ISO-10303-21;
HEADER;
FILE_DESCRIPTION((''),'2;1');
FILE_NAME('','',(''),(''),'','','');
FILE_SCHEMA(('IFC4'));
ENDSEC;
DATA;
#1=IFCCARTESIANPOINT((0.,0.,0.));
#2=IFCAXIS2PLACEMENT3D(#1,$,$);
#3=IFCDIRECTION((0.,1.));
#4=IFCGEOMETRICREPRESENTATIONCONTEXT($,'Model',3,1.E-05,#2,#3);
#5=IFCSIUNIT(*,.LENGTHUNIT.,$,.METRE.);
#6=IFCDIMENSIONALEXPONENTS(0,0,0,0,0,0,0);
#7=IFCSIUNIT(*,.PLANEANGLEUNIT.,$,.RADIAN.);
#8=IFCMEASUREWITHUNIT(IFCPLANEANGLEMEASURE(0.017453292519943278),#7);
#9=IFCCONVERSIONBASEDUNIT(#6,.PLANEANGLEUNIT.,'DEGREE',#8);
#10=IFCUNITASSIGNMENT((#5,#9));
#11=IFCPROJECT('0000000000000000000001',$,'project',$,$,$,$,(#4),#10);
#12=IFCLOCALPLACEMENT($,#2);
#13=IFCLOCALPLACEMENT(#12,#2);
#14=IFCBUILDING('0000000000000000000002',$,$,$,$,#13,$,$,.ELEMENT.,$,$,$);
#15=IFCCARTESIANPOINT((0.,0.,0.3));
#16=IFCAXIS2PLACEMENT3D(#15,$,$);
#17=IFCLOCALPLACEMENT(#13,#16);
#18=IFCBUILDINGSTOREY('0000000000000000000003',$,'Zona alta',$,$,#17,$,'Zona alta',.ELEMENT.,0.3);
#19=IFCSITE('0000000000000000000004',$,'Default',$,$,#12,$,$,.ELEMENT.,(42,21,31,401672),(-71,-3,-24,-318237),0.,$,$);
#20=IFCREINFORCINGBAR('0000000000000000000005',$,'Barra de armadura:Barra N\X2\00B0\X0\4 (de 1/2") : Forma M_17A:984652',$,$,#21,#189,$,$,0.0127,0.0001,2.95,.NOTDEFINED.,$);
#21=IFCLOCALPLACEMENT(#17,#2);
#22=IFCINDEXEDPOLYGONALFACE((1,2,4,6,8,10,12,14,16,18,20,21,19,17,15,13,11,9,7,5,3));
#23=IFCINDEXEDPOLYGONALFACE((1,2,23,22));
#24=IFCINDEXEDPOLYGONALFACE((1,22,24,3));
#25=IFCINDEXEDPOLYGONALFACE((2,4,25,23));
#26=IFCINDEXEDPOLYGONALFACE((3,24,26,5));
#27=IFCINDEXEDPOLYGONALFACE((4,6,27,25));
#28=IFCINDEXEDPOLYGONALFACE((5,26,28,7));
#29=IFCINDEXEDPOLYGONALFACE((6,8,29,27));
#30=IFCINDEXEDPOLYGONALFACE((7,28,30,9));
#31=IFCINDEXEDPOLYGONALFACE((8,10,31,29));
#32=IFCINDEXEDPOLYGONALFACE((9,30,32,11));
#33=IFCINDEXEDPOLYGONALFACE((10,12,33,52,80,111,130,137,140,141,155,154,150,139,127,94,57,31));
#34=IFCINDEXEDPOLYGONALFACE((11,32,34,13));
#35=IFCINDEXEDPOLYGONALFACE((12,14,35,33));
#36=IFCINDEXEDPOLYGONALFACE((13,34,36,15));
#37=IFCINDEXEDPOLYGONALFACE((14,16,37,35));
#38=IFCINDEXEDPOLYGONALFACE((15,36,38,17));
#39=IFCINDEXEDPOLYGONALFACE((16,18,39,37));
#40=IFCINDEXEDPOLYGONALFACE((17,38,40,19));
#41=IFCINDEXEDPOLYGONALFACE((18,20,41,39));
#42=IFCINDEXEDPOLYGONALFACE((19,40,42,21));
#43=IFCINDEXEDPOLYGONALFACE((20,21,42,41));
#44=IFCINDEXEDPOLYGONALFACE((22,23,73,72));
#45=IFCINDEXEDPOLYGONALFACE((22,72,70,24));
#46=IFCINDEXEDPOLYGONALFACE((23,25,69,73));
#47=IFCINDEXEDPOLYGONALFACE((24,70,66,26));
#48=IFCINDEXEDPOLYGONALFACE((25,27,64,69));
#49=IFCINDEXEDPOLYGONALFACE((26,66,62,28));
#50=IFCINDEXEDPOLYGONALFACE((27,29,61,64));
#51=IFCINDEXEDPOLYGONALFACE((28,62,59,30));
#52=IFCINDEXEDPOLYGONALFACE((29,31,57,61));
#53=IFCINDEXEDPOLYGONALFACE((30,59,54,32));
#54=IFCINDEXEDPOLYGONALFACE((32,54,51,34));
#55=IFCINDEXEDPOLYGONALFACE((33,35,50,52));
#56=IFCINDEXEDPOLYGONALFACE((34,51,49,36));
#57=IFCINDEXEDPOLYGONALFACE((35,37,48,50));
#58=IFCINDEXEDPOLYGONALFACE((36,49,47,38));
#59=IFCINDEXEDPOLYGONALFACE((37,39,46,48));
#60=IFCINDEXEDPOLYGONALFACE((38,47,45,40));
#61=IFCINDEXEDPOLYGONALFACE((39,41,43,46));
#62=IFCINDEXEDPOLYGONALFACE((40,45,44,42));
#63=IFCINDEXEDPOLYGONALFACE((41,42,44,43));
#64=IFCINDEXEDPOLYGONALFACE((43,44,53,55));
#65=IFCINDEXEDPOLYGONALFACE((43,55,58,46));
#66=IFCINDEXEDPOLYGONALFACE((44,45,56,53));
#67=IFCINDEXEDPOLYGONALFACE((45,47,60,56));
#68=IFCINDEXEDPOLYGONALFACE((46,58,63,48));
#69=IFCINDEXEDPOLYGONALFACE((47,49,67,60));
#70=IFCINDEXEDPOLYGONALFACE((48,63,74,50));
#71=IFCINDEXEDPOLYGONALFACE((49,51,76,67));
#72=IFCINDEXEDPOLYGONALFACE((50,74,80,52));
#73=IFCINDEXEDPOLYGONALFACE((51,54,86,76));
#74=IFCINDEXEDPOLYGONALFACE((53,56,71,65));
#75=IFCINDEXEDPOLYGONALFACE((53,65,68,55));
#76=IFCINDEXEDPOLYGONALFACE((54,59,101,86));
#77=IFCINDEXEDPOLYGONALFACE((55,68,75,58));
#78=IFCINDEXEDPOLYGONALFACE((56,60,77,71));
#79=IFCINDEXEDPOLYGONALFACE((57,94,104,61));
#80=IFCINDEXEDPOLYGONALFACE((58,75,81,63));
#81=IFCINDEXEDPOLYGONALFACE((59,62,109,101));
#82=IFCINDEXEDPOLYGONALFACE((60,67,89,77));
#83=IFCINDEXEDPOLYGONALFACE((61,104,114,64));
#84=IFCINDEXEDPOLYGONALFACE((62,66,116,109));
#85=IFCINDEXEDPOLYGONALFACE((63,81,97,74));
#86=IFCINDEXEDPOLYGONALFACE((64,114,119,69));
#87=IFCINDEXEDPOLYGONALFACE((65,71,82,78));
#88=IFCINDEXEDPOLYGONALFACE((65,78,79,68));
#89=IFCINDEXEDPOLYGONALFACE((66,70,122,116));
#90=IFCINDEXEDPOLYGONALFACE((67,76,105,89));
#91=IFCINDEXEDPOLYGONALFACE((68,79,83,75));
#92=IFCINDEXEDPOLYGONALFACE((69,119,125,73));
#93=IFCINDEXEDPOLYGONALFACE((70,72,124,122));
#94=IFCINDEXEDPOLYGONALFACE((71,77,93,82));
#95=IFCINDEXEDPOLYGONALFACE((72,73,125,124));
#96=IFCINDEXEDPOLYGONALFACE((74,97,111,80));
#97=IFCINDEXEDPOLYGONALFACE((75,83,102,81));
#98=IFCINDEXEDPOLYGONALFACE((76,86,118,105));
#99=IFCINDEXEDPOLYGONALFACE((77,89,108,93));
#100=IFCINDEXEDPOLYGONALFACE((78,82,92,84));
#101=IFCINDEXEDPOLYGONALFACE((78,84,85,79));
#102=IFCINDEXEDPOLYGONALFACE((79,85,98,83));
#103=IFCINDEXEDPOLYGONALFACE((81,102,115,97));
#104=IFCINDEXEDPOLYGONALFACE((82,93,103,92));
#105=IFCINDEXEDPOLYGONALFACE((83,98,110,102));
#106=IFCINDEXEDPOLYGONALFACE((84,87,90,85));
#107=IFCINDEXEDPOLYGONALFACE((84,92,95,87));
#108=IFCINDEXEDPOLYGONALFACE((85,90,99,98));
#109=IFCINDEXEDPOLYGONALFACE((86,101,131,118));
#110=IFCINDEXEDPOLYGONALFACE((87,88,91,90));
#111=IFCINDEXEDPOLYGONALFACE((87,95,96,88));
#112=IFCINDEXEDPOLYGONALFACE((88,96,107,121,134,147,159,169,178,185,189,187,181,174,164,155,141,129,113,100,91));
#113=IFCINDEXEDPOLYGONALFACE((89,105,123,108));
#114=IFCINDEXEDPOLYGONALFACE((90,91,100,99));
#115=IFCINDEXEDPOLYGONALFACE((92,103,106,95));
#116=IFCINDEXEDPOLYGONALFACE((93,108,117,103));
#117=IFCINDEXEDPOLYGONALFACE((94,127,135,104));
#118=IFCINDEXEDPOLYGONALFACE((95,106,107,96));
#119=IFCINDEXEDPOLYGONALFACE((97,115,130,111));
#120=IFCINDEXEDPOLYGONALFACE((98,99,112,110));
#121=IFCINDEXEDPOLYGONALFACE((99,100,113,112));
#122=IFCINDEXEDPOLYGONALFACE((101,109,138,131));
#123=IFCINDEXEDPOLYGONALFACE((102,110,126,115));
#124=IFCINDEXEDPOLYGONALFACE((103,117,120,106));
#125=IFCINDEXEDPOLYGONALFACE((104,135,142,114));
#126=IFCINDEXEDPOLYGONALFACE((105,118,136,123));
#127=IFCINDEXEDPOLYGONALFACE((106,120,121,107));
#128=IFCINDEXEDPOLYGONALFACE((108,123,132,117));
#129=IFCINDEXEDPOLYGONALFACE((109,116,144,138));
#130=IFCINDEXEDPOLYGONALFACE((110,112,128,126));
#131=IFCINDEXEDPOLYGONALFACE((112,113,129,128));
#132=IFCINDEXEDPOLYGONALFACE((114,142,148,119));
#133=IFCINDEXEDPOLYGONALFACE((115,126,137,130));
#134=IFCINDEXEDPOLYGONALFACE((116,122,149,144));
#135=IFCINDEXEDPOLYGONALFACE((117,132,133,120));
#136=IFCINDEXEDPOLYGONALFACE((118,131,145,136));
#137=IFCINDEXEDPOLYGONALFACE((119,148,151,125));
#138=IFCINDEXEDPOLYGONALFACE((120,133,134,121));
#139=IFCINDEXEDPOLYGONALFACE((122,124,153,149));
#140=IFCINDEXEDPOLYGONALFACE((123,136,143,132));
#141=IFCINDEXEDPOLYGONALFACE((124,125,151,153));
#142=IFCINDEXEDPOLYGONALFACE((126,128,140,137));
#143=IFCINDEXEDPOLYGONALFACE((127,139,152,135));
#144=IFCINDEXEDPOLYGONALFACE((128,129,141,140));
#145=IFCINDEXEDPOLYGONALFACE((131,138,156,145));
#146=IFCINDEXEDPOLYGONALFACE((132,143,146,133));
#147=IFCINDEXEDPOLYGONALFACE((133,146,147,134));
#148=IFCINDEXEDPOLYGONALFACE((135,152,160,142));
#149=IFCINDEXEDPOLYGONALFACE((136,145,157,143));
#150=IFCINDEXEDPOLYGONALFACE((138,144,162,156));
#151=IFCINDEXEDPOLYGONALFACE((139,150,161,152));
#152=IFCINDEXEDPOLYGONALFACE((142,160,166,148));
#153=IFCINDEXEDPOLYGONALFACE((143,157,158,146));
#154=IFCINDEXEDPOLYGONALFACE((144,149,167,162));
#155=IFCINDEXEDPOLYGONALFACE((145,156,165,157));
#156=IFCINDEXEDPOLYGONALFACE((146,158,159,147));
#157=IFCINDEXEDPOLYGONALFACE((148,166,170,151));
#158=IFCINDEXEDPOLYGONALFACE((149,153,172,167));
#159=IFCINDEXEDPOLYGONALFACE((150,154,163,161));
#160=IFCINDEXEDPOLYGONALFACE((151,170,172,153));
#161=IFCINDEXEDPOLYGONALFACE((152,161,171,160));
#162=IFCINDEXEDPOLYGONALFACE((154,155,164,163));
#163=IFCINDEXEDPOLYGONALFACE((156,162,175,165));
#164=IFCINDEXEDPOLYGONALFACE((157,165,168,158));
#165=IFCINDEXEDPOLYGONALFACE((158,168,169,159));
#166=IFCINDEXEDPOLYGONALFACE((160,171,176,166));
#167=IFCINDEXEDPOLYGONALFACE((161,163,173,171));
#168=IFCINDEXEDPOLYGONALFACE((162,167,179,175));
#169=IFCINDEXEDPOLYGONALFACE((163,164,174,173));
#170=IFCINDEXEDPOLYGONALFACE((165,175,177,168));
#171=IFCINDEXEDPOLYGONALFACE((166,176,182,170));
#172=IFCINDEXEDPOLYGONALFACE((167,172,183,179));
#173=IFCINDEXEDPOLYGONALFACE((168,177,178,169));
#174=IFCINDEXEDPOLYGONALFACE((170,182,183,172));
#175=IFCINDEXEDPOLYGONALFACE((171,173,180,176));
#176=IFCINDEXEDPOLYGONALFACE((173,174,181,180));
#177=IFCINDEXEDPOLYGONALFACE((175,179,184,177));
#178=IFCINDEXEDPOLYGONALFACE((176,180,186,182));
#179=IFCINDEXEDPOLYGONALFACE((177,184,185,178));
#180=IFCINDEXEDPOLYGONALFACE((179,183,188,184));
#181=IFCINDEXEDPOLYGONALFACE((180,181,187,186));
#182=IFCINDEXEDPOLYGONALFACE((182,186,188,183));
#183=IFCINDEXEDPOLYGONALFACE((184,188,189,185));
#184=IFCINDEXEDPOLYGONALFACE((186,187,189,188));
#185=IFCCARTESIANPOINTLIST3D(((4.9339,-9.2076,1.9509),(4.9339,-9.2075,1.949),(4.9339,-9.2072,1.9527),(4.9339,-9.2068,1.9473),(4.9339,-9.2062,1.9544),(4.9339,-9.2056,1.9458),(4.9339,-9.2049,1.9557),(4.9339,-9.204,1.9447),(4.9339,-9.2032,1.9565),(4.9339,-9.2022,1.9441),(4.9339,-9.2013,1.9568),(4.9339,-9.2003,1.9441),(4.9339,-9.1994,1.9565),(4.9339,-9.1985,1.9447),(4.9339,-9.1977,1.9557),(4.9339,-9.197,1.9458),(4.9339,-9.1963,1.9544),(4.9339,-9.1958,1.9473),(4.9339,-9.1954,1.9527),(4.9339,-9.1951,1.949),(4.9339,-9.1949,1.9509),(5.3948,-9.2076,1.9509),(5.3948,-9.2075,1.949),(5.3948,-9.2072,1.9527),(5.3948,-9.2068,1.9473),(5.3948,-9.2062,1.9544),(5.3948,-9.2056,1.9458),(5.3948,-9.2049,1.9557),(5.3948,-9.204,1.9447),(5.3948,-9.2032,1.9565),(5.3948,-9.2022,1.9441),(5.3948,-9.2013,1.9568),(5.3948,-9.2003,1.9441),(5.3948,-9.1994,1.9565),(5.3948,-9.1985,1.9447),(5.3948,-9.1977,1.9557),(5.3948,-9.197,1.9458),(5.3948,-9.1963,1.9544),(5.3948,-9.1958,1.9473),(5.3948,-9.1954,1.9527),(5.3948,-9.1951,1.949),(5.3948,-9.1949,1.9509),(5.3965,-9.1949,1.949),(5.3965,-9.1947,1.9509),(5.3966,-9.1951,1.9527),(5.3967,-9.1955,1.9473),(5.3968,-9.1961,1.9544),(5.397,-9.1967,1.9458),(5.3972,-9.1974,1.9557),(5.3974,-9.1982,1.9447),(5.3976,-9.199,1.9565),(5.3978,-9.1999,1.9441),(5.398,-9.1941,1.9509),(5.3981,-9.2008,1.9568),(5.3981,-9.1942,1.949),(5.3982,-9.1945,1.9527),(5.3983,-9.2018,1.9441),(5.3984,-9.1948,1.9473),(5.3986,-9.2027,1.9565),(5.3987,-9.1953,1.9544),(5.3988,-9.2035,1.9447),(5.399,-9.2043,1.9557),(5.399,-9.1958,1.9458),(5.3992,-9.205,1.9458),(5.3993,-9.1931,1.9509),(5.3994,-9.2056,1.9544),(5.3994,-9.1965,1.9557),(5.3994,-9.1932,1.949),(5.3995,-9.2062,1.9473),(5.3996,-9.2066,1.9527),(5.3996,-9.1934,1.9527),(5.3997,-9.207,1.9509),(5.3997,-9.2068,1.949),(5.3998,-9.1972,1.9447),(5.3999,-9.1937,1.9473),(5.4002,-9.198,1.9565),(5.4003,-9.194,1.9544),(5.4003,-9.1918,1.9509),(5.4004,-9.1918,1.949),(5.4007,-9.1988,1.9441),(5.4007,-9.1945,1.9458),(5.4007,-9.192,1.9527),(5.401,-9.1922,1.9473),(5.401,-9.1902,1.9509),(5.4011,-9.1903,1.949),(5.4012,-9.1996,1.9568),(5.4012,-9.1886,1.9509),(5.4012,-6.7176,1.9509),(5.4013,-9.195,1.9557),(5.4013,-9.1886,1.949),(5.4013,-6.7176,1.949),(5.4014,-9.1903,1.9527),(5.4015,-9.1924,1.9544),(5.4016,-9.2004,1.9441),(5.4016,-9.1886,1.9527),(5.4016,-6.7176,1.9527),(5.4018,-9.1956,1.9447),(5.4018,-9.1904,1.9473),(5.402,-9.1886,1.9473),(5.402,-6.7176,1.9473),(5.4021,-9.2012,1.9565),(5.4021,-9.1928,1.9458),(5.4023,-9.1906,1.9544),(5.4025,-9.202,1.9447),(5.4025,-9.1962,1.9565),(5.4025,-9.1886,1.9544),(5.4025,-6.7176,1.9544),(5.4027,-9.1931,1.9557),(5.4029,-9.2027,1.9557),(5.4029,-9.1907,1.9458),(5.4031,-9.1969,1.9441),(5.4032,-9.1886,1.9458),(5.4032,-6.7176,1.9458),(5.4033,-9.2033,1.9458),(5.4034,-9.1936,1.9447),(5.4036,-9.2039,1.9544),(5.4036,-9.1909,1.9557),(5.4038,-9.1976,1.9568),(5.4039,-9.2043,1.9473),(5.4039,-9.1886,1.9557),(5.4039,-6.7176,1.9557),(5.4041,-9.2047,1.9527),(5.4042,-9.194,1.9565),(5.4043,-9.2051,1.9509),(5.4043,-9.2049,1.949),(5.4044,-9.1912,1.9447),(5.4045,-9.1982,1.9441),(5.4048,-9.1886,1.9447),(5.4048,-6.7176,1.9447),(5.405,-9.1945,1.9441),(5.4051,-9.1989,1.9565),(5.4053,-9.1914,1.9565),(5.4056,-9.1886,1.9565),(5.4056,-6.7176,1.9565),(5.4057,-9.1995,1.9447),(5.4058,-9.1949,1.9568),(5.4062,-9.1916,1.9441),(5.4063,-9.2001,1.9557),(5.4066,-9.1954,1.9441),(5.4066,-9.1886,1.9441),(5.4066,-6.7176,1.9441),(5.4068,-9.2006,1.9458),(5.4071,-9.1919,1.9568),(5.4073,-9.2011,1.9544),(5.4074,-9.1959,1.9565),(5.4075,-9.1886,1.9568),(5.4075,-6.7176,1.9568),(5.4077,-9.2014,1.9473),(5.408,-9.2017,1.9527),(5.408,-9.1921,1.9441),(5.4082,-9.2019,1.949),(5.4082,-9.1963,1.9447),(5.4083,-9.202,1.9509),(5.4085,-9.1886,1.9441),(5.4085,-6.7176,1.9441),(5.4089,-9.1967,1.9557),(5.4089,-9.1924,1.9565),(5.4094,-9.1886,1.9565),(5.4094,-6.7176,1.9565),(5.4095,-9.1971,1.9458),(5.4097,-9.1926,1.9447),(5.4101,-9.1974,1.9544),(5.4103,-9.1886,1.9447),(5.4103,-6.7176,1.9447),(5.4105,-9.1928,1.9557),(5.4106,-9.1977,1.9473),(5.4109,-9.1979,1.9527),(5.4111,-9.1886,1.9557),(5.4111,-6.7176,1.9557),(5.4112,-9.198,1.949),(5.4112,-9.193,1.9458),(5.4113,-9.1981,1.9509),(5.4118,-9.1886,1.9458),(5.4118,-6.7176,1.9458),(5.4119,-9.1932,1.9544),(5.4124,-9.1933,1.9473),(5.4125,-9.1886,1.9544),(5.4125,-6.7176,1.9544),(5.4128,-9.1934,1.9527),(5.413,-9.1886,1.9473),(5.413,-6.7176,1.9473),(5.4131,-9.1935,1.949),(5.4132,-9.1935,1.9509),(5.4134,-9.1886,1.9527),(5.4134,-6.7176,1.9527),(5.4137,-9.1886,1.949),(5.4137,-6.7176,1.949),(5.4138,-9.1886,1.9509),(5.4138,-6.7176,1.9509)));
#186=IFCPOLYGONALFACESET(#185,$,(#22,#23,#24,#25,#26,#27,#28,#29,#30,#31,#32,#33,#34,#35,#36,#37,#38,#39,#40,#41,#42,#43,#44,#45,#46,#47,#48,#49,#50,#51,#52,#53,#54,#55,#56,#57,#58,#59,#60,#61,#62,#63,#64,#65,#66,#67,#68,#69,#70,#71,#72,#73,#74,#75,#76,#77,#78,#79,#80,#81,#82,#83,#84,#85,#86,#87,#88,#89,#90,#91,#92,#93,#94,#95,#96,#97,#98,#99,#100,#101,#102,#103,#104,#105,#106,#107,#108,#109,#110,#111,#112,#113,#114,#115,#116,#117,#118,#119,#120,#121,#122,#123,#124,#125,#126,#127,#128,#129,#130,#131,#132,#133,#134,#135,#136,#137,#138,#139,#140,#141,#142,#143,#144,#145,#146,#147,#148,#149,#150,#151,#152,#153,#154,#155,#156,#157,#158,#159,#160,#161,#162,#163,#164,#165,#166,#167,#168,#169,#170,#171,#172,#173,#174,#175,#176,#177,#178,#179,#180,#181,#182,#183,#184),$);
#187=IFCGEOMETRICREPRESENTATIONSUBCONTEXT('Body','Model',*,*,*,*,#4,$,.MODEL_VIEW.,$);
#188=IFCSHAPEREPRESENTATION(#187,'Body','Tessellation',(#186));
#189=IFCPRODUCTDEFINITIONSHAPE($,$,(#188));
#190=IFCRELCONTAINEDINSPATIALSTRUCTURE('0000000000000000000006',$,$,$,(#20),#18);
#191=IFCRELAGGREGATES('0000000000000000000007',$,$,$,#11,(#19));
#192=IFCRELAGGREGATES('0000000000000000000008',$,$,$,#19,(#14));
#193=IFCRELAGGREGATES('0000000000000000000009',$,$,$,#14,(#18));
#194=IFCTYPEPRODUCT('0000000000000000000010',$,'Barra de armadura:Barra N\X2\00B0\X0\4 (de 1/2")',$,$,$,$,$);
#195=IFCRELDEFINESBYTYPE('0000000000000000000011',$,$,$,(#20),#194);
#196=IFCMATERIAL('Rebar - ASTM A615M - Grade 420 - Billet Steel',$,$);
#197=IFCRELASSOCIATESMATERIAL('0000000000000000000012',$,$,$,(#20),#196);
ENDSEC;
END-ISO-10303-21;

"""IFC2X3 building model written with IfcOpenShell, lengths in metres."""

from ifc_helpers import new_model, entity, si_unit, converted_unit, direction, frame, origin, place, context, subcontext, project, spatial, material, type_object, element, save


model = new_model("IFC2X3")

# Units and contexts
model_context = context("Model", 3, precision=1e-05, world=origin(), true_north=direction((0.0, 1.0)))
body_context = subcontext(model_context, "Body", "Model", "MODEL_VIEW")
ifc_project = project(units=[si_unit("LENGTHUNIT", "METRE"), converted_unit("PLANEANGLEUNIT", "DEGREE", entity("IfcPlaneAngleMeasure", 0.017453292519943278), si_unit("PLANEANGLEUNIT", "RADIAN"), dimensions=[0, 0, 0, 0, 0, 0, 0])], contexts=[model_context])

# Site, building, storey
site_placement = place(None, origin())
site = spatial("IfcSite", under=ifc_project, at=site_placement, Name="Default", CompositionType="ELEMENT", RefLatitude=(42, 21, 31, 401672), RefLongitude=(-71, -3, -24, -318237), RefElevation=0.0)
building_placement = place(site_placement, origin())
building = spatial("IfcBuilding", under=site, at=building_placement, CompositionType="ELEMENT")
storey_placement = place(building_placement, frame((0.0, 0.0, 0.3)))
storey = spatial("IfcBuildingStorey", under=building, at=storey_placement, Name="Zona alta", LongName="Zona alta", CompositionType="ELEMENT", Elevation=0.3)

# Reinforcing bar
ifc_material_1 = material(Name="Rebar - ASTM A615M - Grade 420 - Billet Steel")
type_product_1 = type_object("IfcTypeProduct", Name="Barra de armadura:Barra N°4 (de 1/2\")")
reinforcing_bar_1_placement = place(storey_placement, origin())
element("IfcReinforcingBar", 1, at=reinforcing_bar_1_placement, inside=storey, type_object=type_product_1, material=ifc_material_1, Name="Barra de armadura:Barra N°4 (de 1/2\") : Forma M_17A:984652", BarLength=2.95, BarRole="NOTDEFINED", CrossSectionArea=0.0001, NominalDiameter=0.0127, context=body_context, shape_type="AdvancedSweptSolid", body=[
    entity("IfcSweptDiskSolid", entity("IfcCompositeCurve", [entity("IfcCompositeCurveSegment", "CONTINUOUS", True, entity("IfcPolyline", [entity("IfcCartesianPoint", [4.9339, -9.2013, 1.9504]), entity("IfcCartesianPoint", [5.3948, -9.2013, 1.9504])])), entity("IfcCompositeCurveSegment", "CONTINUOUS", True, entity("IfcTrimmedCurve", entity("IfcCircle", entity("IfcAxis2Placement3D", entity("IfcCartesianPoint", [5.3948, -9.1886, 1.9504])), 0.0127), [entity("IfcParameterValue", 270.0)], [entity("IfcParameterValue", 360.0)], True, "PARAMETER")), entity("IfcCompositeCurveSegment", "CONTINUOUS", True, entity("IfcPolyline", [entity("IfcCartesianPoint", [5.4075, -9.1886, 1.9504]), entity("IfcCartesianPoint", [5.4075, -6.7176, 1.9504])]))], False), 0.0063, None, 0.0, 92.0),
])

save(model, "model.ifc")
